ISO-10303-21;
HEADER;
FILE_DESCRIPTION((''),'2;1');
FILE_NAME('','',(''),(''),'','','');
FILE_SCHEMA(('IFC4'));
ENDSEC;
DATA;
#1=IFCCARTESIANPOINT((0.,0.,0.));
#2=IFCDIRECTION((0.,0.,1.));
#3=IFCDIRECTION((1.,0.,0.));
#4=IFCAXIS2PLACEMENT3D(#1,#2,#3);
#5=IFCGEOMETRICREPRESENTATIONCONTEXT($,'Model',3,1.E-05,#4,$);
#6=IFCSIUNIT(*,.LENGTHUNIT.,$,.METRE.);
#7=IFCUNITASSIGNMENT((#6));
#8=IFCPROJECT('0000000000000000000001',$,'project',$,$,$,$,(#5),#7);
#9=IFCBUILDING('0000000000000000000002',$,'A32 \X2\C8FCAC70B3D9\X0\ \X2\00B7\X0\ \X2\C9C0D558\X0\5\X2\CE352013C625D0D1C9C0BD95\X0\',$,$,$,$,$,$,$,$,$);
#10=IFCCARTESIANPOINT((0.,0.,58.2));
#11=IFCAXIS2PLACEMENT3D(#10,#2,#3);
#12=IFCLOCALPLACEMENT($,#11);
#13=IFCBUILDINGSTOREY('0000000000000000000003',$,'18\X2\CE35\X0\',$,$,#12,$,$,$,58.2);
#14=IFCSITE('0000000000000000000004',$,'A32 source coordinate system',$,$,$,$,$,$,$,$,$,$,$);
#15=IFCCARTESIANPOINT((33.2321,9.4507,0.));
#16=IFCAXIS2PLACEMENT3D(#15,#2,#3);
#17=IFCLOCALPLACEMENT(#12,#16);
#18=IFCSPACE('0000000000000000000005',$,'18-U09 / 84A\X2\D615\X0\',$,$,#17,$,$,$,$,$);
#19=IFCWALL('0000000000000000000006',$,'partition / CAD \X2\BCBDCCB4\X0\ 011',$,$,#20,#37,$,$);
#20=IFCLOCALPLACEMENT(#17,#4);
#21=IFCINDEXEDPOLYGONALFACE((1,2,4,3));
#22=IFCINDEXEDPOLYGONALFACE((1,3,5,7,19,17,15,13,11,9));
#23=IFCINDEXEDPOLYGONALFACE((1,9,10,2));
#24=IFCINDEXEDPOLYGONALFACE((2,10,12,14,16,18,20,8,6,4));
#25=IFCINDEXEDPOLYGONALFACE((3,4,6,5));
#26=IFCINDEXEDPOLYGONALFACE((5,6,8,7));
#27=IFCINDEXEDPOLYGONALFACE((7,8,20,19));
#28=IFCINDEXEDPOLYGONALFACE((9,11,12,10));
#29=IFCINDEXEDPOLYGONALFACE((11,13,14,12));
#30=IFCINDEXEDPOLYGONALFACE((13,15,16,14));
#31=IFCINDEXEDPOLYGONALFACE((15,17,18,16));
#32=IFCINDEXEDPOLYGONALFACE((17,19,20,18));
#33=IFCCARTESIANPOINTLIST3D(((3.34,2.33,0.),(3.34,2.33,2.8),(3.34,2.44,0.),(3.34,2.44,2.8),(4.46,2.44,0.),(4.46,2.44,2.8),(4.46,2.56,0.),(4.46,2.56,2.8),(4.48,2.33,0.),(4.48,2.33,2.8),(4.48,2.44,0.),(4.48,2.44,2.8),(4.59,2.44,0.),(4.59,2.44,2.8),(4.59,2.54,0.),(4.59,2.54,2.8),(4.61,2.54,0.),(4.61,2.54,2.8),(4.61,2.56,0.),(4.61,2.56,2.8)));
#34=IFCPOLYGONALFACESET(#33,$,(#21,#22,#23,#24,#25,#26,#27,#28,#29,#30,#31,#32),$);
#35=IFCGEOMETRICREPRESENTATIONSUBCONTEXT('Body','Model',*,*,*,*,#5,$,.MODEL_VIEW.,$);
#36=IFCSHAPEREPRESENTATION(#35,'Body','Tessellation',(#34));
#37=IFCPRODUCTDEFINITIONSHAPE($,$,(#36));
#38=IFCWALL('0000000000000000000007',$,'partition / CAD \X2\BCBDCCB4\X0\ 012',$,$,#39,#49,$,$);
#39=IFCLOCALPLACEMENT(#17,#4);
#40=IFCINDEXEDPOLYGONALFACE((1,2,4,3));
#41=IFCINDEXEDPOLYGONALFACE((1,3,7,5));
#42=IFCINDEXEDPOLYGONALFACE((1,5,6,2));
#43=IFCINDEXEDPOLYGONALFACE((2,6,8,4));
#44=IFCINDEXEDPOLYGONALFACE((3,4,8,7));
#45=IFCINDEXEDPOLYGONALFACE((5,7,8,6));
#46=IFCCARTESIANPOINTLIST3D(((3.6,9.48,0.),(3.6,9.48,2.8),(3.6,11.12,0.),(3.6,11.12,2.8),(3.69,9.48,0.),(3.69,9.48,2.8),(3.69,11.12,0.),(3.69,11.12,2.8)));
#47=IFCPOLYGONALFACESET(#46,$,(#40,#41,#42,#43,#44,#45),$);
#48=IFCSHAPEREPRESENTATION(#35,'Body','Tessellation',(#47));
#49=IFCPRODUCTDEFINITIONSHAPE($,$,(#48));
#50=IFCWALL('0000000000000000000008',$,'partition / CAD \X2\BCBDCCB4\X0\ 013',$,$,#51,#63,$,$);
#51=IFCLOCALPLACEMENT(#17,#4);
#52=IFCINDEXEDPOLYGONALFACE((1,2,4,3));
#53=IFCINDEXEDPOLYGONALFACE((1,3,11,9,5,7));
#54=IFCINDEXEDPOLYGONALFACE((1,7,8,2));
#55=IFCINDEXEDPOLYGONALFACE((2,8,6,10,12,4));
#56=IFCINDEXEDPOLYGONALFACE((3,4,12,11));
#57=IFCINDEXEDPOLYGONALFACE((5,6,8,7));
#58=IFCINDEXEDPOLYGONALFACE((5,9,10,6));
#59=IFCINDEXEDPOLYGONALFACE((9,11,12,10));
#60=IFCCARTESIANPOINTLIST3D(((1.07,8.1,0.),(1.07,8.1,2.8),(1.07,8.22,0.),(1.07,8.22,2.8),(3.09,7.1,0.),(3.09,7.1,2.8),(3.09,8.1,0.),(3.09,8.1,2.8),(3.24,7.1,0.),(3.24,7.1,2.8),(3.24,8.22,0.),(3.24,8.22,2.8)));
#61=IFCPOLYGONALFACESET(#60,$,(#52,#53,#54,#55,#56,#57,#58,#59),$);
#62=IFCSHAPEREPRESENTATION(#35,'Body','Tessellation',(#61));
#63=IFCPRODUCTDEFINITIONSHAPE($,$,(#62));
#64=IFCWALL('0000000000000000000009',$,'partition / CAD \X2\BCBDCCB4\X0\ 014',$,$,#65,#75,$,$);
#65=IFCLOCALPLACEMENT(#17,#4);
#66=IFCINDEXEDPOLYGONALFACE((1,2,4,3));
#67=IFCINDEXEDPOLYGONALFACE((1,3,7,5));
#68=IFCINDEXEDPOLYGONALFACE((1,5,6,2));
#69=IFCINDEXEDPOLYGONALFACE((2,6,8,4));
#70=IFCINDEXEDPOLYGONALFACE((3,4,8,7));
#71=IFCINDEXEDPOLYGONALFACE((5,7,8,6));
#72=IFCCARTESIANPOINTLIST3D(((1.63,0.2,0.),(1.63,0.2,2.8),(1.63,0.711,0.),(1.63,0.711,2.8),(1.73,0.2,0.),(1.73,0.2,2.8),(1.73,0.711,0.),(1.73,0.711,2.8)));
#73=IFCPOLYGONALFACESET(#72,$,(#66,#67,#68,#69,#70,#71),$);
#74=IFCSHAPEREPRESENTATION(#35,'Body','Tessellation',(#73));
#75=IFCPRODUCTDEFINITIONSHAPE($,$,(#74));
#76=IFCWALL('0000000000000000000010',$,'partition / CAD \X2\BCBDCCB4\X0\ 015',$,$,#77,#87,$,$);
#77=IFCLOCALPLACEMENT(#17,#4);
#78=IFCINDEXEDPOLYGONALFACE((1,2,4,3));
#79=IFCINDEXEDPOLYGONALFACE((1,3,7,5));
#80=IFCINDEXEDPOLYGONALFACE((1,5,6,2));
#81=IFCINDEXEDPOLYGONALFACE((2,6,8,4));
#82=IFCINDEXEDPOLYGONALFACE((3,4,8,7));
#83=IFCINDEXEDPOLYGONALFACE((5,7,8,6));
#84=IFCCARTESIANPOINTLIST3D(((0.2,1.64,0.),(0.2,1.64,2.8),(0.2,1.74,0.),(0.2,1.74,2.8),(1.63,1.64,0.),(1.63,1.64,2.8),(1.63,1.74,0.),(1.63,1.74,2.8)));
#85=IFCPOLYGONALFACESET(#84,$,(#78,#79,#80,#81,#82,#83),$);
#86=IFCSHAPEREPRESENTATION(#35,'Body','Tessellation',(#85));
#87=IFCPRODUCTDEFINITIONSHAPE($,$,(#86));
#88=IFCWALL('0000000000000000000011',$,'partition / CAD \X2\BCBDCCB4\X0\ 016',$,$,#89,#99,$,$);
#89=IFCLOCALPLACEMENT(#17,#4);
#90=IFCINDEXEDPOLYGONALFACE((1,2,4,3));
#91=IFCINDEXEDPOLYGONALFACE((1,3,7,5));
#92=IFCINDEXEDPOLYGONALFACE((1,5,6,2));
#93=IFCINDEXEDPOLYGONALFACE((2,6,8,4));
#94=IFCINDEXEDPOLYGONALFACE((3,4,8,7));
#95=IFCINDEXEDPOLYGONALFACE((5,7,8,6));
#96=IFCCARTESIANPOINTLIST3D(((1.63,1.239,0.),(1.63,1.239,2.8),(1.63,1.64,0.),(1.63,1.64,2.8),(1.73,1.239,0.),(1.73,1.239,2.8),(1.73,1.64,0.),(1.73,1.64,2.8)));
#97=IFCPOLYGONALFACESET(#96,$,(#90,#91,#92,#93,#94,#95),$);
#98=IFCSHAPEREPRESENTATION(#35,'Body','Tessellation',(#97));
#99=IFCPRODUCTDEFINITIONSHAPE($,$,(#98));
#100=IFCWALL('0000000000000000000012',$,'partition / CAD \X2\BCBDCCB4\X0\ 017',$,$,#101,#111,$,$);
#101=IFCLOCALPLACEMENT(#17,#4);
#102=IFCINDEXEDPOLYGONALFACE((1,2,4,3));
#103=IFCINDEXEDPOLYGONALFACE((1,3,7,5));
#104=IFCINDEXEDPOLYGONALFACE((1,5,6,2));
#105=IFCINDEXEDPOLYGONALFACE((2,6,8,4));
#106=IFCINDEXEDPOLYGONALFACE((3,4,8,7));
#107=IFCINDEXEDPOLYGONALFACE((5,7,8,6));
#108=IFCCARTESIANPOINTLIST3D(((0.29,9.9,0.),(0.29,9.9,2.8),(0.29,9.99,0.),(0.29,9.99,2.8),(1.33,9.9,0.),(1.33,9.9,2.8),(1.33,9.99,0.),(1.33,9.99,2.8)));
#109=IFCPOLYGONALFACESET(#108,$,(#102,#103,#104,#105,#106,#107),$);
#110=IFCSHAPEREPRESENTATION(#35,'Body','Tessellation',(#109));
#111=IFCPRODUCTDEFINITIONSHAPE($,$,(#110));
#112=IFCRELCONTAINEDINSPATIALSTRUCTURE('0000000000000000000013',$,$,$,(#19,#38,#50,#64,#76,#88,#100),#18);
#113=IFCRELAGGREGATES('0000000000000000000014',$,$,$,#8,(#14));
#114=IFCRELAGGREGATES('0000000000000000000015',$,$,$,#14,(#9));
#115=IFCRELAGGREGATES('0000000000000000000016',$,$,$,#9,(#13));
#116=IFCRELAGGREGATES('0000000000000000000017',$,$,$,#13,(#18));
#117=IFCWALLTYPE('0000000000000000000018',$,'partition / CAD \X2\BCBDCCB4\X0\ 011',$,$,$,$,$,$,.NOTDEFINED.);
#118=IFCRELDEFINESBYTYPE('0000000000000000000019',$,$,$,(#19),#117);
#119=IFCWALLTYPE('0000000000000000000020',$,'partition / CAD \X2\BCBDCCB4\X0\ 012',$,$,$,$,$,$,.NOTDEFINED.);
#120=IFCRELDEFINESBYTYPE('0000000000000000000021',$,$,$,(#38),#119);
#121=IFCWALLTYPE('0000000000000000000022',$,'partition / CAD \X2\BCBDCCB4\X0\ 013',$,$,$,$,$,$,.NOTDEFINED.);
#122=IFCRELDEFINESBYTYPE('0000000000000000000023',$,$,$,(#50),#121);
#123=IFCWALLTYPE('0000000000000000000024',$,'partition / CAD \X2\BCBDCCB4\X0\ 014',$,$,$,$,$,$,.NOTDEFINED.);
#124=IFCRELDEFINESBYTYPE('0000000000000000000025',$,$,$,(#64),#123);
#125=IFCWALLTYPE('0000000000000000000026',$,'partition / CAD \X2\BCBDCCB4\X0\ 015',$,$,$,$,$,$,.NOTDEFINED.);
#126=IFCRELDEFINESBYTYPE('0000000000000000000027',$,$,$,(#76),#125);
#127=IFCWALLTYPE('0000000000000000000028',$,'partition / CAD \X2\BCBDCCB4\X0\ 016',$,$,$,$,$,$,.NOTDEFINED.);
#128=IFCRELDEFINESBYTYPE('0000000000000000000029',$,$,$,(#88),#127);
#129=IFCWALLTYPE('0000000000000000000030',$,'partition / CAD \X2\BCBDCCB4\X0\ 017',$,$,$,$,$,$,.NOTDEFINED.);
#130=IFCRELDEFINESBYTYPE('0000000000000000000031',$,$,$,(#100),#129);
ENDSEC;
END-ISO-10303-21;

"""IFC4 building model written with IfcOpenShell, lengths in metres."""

from ifc_helpers import new_model, si_unit, frame, origin, origin_with_axes, place, context, subcontext, project, spatial, polyline, outline, extrude, source, transform, mapped, type_object, type_shapes, element, save


model = new_model("IFC4")

# Units and contexts
model_context = context("Model", 3, precision=1e-05, world=origin_with_axes())
body_context = subcontext(model_context, "Body", "Model", "MODEL_VIEW")
ifc_project = project(units=[si_unit("LENGTHUNIT", "METRE")], contexts=[model_context])

# Site, building, storey, space
storey_placement = place(None, frame((0.0, 0.0, 58.2), z_axis=(0.0, 0.0, 1.0), x_axis=(1.0, 0.0, 0.0)))
space_placement = place(storey_placement, frame((33.2321, 9.4507, 0.0), z_axis=(0.0, 0.0, 1.0), x_axis=(1.0, 0.0, 0.0)))
site = spatial("IfcSite", under=ifc_project, Name="A32 source coordinate system")
building = spatial("IfcBuilding", under=site, Name="A32 주거동 · 지하5층–옥탑지붕")
storey = spatial("IfcBuildingStorey", under=building, at=storey_placement, Name="18층", Elevation=58.2)
space = spatial("IfcSpace", under=storey, at=space_placement, Name="18-U09 / 84A형")

# Walls
wall_type_1 = type_object("IfcWallType", Name="partition / CAD 벽체 011", PredefinedType="NOTDEFINED")
shared_shape_1 = source(origin(), body_context, "Body", "SweptSolid", [
    extrude(outline(polyline([(3.34, 2.33), (3.34, 2.44), (4.46, 2.44), (4.46, 2.56), (4.61, 2.56), (4.61, 2.54), (4.59, 2.54), (4.59, 2.44), (4.48, 2.44), (4.48, 2.33), (3.34, 2.33)])), origin(), (0.0, 0.0, 1.0), 2.8),
])
type_shapes(wall_type_1, [shared_shape_1])
wall_1_placement = place(space_placement, origin_with_axes())
element("IfcWall", 1, at=wall_1_placement, inside=space, type_object=wall_type_1, Name="partition / CAD 벽체 011", context=body_context, shape_type="MappedRepresentation", body=[
    mapped(shared_shape_1, transform((0.0, 0.0, 0.0), scale=1.0)),
])
wall_type_2 = type_object("IfcWallType", Name="partition / CAD 벽체 012", PredefinedType="NOTDEFINED")
shared_shape_2 = source(origin(), body_context, "Body", "SweptSolid", [
    extrude(outline(polyline([(3.6, 11.12), (3.69, 11.12), (3.69, 9.48), (3.6, 9.48), (3.6, 11.12)])), origin(), (0.0, 0.0, 1.0), 2.8),
])
type_shapes(wall_type_2, [shared_shape_2])
wall_2_placement = place(space_placement, origin_with_axes())
element("IfcWall", 2, at=wall_2_placement, inside=space, type_object=wall_type_2, Name="partition / CAD 벽체 012", context=body_context, shape_type="MappedRepresentation", body=[
    mapped(shared_shape_2, transform((0.0, 0.0, 0.0), scale=1.0)),
])
wall_type_3 = type_object("IfcWallType", Name="partition / CAD 벽체 013", PredefinedType="NOTDEFINED")
shared_shape_3 = source(origin(), body_context, "Body", "SweptSolid", [
    extrude(outline(polyline([(3.09, 8.1), (1.07, 8.1), (1.07, 8.22), (3.24, 8.22), (3.24, 7.1), (3.09, 7.1), (3.09, 8.1)])), origin(), (0.0, 0.0, 1.0), 2.8),
])
type_shapes(wall_type_3, [shared_shape_3])
wall_3_placement = place(space_placement, origin_with_axes())
element("IfcWall", 3, at=wall_3_placement, inside=space, type_object=wall_type_3, Name="partition / CAD 벽체 013", context=body_context, shape_type="MappedRepresentation", body=[
    mapped(shared_shape_3, transform((0.0, 0.0, 0.0), scale=1.0)),
])
wall_type_4 = type_object("IfcWallType", Name="partition / CAD 벽체 014", PredefinedType="NOTDEFINED")
shared_shape_4 = source(origin(), body_context, "Body", "SweptSolid", [
    extrude(outline(polyline([(1.73, 0.2), (1.63, 0.2), (1.63, 0.711), (1.73, 0.711), (1.73, 0.2)])), origin(), (0.0, 0.0, 1.0), 2.8),
])
type_shapes(wall_type_4, [shared_shape_4])
wall_4_placement = place(space_placement, origin_with_axes())
element("IfcWall", 4, at=wall_4_placement, inside=space, type_object=wall_type_4, Name="partition / CAD 벽체 014", context=body_context, shape_type="MappedRepresentation", body=[
    mapped(shared_shape_4, transform((0.0, 0.0, 0.0), scale=1.0)),
])
wall_type_5 = type_object("IfcWallType", Name="partition / CAD 벽체 015", PredefinedType="NOTDEFINED")
shared_shape_5 = source(origin(), body_context, "Body", "SweptSolid", [
    extrude(outline(polyline([(1.63, 1.74), (1.63, 1.64), (0.2, 1.64), (0.2, 1.74), (1.63, 1.74)])), origin(), (0.0, 0.0, 1.0), 2.8),
])
type_shapes(wall_type_5, [shared_shape_5])
wall_5_placement = place(space_placement, origin_with_axes())
element("IfcWall", 5, at=wall_5_placement, inside=space, type_object=wall_type_5, Name="partition / CAD 벽체 015", context=body_context, shape_type="MappedRepresentation", body=[
    mapped(shared_shape_5, transform((0.0, 0.0, 0.0), scale=1.0)),
])
wall_type_6 = type_object("IfcWallType", Name="partition / CAD 벽체 016", PredefinedType="NOTDEFINED")
shared_shape_6 = source(origin(), body_context, "Body", "SweptSolid", [
    extrude(outline(polyline([(1.73, 1.239), (1.63, 1.239), (1.63, 1.64), (1.73, 1.64), (1.73, 1.239)])), origin(), (0.0, 0.0, 1.0), 2.8),
])
type_shapes(wall_type_6, [shared_shape_6])
wall_6_placement = place(space_placement, origin_with_axes())
element("IfcWall", 6, at=wall_6_placement, inside=space, type_object=wall_type_6, Name="partition / CAD 벽체 016", context=body_context, shape_type="MappedRepresentation", body=[
    mapped(shared_shape_6, transform((0.0, 0.0, 0.0), scale=1.0)),
])
wall_type_7 = type_object("IfcWallType", Name="partition / CAD 벽체 017", PredefinedType="NOTDEFINED")
shared_shape_7 = source(origin(), body_context, "Body", "SweptSolid", [
    extrude(outline(polyline([(1.33, 9.99), (1.33, 9.9), (0.29, 9.9), (0.29, 9.99), (1.33, 9.99)])), origin(), (0.0, 0.0, 1.0), 2.8),
])
type_shapes(wall_type_7, [shared_shape_7])
wall_7_placement = place(space_placement, origin_with_axes())
element("IfcWall", 7, at=wall_7_placement, inside=space, type_object=wall_type_7, Name="partition / CAD 벽체 017", context=body_context, shape_type="MappedRepresentation", body=[
    mapped(shared_shape_7, transform((0.0, 0.0, 0.0), scale=1.0)),
])

save(model, "model.ifc")
